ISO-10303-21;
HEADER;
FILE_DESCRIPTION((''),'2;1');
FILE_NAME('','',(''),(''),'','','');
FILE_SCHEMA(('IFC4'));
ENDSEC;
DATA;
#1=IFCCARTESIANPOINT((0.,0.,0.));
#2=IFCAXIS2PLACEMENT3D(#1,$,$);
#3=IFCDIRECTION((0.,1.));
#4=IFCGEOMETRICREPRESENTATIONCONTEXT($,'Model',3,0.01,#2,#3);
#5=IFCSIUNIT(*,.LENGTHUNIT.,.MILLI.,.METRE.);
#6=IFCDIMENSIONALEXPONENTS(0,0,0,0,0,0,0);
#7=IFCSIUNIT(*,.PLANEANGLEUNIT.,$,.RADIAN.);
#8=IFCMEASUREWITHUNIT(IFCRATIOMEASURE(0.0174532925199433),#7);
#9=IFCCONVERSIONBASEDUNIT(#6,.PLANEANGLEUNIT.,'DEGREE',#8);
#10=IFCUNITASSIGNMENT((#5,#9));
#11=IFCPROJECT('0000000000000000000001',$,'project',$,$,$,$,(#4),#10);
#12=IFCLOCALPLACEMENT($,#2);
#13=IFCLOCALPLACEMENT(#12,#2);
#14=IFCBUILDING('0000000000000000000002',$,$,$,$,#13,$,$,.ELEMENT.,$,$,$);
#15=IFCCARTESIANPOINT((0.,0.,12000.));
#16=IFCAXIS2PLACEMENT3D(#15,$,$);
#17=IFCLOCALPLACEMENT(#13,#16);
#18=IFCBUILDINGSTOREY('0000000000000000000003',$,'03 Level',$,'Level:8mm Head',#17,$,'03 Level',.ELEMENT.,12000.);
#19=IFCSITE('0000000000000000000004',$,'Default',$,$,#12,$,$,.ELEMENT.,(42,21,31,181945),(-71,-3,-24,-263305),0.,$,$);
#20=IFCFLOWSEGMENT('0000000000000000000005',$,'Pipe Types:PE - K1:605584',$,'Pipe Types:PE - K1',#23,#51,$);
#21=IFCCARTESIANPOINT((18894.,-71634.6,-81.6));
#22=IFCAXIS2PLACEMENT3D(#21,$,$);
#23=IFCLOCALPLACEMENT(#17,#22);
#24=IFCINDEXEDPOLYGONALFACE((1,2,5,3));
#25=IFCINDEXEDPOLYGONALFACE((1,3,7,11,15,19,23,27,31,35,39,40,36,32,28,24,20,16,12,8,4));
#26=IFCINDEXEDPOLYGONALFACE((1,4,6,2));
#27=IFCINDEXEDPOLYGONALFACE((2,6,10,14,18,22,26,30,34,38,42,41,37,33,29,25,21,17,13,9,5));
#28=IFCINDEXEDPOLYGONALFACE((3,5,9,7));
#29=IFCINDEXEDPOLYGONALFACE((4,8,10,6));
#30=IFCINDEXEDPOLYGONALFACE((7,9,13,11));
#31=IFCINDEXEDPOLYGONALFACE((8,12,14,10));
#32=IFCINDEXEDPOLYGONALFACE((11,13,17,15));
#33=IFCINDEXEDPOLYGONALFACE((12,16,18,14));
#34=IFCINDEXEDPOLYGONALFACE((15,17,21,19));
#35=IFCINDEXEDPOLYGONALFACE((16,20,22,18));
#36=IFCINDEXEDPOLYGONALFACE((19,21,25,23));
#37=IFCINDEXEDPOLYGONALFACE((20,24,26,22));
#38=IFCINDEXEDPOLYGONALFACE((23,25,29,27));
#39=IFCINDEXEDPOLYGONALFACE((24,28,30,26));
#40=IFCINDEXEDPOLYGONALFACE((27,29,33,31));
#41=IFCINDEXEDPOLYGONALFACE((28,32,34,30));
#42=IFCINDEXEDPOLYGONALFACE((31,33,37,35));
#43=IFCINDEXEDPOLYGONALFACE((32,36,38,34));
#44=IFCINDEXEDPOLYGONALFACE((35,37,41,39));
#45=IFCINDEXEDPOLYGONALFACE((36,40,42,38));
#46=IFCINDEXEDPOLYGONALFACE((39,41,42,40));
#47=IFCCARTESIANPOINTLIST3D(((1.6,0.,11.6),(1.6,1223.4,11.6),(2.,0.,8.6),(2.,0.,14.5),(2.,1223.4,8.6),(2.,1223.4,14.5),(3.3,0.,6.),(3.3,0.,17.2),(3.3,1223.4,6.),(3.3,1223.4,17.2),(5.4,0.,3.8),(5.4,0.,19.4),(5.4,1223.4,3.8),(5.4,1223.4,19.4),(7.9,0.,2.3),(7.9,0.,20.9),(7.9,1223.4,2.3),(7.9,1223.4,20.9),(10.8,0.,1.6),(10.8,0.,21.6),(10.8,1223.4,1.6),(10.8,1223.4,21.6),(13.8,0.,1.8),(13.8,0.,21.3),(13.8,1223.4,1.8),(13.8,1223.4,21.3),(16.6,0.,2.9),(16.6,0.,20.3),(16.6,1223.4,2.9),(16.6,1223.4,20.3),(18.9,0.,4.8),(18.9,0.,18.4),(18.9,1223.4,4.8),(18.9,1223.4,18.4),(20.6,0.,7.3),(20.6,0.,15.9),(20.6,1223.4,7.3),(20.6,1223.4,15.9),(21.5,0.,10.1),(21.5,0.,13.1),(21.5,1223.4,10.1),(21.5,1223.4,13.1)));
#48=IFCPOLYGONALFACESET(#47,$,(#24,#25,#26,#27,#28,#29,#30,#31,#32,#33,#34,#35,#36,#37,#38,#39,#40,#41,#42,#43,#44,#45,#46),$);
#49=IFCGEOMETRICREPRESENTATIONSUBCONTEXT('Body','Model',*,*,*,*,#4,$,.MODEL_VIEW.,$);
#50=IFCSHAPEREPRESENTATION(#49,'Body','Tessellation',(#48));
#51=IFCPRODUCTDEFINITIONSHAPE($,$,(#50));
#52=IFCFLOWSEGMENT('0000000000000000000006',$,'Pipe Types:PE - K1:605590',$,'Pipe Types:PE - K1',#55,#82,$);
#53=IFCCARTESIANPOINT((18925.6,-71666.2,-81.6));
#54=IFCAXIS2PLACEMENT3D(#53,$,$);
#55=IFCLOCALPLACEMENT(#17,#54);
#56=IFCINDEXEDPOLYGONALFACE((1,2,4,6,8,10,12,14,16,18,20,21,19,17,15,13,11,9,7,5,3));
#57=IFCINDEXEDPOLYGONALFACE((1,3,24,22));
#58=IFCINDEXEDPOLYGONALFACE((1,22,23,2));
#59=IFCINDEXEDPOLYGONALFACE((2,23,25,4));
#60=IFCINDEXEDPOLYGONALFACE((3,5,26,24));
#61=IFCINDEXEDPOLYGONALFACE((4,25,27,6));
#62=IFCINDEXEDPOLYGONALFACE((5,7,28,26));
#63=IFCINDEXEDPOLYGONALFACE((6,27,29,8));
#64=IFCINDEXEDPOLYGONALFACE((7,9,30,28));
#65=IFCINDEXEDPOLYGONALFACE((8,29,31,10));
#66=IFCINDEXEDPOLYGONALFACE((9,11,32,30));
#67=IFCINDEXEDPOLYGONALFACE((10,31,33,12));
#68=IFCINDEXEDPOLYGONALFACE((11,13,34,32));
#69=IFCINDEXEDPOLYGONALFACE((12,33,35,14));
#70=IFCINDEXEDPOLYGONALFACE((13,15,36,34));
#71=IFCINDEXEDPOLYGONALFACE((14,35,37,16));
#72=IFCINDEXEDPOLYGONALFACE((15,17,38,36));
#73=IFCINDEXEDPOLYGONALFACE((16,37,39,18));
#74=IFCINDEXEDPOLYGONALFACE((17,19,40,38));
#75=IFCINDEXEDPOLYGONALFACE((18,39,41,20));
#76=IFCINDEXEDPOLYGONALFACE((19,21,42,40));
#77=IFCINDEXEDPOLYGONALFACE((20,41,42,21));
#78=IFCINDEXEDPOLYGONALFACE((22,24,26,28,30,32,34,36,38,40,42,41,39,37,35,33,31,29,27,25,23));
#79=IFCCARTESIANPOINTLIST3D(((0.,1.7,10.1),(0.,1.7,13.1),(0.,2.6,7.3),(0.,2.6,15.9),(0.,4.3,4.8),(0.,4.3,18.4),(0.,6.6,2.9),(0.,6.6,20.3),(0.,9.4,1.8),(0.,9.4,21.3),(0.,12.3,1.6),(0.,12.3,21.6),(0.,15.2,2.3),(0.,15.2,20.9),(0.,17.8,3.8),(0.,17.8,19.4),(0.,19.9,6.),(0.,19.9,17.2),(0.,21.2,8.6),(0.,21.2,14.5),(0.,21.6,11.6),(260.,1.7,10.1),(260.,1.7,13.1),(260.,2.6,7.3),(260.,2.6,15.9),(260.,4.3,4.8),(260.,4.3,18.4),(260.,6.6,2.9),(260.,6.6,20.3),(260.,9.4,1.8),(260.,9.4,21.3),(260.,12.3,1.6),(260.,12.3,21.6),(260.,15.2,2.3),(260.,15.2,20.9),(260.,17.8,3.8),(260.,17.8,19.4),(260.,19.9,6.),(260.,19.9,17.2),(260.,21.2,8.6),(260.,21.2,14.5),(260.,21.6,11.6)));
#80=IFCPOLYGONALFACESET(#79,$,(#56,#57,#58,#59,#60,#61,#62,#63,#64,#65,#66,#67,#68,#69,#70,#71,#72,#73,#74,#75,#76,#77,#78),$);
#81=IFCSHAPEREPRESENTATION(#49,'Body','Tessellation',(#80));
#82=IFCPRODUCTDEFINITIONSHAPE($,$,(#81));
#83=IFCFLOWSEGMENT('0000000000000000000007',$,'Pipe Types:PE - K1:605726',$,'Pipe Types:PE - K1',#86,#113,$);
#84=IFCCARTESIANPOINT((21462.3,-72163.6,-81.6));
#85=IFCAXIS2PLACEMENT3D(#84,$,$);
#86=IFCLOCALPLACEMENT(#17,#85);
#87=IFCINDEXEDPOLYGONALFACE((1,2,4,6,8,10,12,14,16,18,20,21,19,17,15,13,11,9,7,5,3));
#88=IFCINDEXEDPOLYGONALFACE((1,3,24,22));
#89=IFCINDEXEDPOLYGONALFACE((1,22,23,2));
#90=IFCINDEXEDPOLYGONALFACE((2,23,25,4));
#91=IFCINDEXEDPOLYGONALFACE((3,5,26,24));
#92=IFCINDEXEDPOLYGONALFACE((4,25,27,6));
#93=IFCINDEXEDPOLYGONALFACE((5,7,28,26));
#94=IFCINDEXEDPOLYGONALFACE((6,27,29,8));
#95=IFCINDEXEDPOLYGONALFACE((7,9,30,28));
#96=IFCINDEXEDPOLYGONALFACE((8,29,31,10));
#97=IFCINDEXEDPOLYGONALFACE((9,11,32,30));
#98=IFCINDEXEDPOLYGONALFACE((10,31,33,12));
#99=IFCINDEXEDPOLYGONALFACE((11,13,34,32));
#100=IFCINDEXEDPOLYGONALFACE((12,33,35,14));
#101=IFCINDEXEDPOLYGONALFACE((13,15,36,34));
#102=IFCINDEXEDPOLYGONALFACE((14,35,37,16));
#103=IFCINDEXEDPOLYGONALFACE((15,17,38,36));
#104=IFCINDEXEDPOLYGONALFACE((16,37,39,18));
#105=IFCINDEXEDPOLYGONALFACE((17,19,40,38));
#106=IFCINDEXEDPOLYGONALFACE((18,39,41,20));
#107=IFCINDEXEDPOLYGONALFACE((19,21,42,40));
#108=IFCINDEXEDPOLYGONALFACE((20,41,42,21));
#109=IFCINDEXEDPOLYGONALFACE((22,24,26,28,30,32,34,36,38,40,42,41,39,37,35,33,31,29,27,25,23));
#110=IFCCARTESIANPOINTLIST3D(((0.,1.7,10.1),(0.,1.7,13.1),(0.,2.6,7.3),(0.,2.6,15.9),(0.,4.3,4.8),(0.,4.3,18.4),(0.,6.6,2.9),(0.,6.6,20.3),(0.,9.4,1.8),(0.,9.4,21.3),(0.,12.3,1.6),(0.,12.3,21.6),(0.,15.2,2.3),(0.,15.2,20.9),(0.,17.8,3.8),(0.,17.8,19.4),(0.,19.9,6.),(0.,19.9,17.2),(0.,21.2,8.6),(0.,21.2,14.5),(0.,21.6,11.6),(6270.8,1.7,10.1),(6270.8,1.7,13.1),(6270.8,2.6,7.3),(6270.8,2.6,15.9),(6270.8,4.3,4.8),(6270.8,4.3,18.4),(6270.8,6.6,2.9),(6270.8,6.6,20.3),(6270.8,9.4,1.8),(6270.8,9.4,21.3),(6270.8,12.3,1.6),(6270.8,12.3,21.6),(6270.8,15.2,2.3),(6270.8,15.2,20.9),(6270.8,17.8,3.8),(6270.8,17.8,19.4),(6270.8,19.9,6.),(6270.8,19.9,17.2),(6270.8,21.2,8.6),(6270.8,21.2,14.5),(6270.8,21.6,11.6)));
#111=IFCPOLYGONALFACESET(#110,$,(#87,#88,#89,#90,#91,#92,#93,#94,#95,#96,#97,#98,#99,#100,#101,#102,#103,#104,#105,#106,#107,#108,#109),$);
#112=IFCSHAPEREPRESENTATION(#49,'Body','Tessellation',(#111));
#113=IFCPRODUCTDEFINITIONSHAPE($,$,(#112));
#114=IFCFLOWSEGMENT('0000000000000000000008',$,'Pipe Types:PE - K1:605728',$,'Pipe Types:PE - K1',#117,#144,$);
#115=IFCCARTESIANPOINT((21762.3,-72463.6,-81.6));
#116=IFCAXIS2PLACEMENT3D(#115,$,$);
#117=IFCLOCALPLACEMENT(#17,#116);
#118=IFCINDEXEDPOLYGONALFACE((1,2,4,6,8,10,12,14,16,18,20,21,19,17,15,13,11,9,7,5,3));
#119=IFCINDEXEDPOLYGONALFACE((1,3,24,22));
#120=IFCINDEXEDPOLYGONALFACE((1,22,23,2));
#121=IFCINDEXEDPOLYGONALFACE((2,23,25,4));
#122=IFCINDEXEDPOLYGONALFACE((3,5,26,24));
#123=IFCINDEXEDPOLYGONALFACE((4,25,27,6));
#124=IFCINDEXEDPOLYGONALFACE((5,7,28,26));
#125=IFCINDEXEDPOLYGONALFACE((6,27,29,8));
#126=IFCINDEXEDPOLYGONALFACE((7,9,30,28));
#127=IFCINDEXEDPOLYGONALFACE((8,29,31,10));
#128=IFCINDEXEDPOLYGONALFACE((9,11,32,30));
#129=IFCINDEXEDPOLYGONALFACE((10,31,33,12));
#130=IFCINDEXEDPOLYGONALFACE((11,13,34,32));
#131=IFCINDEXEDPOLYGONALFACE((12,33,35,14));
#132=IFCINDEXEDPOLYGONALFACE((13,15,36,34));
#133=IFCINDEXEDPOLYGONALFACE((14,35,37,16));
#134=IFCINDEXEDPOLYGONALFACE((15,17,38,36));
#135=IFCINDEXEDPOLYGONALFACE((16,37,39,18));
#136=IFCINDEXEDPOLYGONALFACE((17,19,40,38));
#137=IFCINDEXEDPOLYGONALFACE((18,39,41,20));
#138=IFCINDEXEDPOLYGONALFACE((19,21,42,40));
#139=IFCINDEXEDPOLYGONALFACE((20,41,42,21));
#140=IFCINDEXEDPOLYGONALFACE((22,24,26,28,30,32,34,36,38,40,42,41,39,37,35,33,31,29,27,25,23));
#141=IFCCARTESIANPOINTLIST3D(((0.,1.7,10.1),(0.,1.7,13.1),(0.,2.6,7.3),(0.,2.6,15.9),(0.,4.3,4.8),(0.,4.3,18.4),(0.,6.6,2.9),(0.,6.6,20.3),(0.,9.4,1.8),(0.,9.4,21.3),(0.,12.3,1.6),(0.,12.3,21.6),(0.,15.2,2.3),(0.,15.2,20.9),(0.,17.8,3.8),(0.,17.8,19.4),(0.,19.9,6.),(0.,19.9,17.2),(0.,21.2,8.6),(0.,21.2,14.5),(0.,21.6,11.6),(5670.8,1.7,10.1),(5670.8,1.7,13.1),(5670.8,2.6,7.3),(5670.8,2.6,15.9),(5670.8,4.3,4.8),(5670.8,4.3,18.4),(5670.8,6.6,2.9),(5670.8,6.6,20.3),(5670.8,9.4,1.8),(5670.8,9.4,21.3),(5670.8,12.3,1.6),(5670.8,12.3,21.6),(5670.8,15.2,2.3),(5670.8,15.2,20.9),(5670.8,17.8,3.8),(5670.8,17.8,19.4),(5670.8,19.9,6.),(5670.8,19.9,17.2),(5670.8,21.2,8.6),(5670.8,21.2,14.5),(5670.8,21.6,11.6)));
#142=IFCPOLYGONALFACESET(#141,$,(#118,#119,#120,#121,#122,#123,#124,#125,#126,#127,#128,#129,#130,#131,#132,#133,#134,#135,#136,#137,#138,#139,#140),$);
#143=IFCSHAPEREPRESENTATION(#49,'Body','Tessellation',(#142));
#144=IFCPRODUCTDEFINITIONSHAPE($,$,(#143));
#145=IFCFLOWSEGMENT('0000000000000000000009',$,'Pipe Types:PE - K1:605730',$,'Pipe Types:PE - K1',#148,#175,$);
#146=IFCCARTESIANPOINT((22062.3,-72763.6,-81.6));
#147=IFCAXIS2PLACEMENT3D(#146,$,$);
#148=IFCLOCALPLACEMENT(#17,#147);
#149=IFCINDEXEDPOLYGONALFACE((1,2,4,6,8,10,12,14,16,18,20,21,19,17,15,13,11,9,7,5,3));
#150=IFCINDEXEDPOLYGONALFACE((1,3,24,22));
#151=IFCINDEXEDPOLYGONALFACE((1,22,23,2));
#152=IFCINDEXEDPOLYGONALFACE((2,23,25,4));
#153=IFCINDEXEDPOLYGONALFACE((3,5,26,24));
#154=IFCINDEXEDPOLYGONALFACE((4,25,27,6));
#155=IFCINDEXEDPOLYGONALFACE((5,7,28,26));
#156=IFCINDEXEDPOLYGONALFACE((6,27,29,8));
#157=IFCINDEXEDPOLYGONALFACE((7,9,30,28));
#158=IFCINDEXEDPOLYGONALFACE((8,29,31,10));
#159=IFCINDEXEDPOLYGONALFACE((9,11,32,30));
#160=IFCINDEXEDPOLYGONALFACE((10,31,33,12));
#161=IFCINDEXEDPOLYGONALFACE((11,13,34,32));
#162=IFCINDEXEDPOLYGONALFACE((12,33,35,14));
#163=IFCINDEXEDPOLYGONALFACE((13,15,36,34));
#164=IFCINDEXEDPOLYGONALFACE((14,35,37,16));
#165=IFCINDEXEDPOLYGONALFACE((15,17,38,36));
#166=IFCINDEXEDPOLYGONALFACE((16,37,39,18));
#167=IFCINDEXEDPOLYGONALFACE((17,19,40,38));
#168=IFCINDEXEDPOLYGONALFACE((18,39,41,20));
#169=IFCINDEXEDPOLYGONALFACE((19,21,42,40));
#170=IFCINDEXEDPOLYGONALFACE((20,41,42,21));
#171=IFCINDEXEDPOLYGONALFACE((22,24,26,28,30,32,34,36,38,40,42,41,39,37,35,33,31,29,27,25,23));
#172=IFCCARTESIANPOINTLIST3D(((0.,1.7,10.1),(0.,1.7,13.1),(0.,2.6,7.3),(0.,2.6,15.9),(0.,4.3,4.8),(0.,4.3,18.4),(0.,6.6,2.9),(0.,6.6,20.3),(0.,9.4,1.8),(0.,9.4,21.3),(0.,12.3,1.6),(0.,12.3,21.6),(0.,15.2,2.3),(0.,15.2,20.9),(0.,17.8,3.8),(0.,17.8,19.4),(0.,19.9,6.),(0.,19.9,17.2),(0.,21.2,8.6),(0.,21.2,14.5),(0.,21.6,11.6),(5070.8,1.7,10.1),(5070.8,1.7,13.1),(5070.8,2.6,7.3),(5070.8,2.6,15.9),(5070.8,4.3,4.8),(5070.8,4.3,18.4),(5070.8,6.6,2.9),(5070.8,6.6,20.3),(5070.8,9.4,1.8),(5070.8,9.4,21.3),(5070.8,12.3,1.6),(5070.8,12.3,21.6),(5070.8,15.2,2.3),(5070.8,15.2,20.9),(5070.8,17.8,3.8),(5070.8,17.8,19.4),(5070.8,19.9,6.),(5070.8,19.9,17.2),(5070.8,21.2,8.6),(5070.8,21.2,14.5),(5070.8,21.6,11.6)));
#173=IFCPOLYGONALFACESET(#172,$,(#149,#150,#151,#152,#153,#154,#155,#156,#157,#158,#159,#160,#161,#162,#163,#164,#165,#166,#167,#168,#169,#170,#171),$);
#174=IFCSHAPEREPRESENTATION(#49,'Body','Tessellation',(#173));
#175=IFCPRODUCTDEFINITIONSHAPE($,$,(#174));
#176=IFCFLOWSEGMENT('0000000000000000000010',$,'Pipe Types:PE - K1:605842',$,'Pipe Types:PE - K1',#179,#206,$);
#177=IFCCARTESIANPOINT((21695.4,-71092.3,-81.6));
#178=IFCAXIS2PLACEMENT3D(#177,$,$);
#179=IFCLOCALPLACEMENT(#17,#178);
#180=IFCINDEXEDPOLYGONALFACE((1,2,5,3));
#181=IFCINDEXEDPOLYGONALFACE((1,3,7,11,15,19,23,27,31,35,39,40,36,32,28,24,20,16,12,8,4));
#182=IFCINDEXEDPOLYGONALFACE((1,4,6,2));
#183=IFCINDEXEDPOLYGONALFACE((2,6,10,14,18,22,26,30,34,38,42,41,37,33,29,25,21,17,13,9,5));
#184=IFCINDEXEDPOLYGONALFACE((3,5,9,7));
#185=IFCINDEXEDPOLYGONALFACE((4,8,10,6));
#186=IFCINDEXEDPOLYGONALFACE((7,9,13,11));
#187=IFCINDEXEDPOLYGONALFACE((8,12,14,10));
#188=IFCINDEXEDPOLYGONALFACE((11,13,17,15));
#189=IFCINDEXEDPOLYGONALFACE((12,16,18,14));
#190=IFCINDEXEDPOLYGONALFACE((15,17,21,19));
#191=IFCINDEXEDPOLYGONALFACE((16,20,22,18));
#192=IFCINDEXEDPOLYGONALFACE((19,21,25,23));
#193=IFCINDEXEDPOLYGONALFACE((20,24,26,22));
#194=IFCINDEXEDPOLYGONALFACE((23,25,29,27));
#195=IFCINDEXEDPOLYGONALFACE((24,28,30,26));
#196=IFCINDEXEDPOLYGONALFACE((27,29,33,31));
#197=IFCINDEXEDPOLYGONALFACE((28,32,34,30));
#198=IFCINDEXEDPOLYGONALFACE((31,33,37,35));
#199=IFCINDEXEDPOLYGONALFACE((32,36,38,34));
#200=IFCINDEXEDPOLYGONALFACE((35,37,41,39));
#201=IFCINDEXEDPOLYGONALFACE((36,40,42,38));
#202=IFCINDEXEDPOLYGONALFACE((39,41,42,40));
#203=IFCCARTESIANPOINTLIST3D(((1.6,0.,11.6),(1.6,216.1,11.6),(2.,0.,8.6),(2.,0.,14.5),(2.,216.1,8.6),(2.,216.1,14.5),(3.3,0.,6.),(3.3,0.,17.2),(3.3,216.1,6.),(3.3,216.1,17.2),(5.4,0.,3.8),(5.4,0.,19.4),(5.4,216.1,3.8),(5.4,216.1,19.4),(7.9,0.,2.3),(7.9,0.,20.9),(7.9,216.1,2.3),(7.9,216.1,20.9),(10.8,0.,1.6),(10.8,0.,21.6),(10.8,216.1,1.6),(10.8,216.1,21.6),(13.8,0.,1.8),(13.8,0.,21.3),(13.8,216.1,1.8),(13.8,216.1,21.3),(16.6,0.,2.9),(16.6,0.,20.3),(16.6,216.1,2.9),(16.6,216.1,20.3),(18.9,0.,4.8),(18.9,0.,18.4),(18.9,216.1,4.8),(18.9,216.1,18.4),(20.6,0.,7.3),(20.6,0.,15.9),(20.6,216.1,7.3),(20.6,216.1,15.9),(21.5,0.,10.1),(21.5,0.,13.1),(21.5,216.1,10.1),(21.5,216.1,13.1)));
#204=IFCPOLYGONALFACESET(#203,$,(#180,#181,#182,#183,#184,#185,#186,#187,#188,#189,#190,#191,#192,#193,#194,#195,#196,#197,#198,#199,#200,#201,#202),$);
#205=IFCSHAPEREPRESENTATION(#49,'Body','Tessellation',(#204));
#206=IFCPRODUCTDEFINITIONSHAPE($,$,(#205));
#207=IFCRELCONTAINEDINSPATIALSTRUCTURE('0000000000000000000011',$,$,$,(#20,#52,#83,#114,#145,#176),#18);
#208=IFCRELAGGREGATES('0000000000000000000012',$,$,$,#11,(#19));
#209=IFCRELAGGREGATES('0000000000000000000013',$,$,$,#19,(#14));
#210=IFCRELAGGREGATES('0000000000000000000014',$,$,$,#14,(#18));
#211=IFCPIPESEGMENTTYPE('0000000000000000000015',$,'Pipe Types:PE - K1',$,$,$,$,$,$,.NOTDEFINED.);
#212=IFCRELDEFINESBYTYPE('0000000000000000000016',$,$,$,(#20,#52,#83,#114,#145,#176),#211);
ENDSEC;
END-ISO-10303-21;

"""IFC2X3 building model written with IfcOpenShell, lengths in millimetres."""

from ifc_helpers import new_model, entity, si_unit, converted_unit, direction, frame, frame_2d, origin, place, context, subcontext, project, spatial, circle, extrude, type_object, element, save


model = new_model("IFC2X3")

# Units and contexts
model_context = context("Model", 3, precision=0.01, world=origin(), true_north=direction((0.0, 1.0)))
body_context = subcontext(model_context, "Body", "Model", "MODEL_VIEW")
ifc_project = project(units=[si_unit("LENGTHUNIT", "METRE", prefix="MILLI"), converted_unit("PLANEANGLEUNIT", "DEGREE", entity("IfcRatioMeasure", 0.0174532925199433), si_unit("PLANEANGLEUNIT", "RADIAN"), dimensions=[0, 0, 0, 0, 0, 0, 0])], contexts=[model_context])

# Site, building, storey
site_placement = place(None, origin())
site = spatial("IfcSite", under=ifc_project, at=site_placement, Name="Default", CompositionType="ELEMENT", RefLatitude=(42, 21, 31, 181945), RefLongitude=(-71, -3, -24, -263305), RefElevation=0.0)
building_placement = place(site_placement, origin())
building = spatial("IfcBuilding", under=site, at=building_placement, CompositionType="ELEMENT")
storey_placement = place(building_placement, frame((0.0, 0.0, 12000.0)))
storey = spatial("IfcBuildingStorey", under=building, at=storey_placement, Name="03 Level", ObjectType="Level:8mm Head", LongName="03 Level", CompositionType="ELEMENT", Elevation=12000.0)

# Flow segments
pipe_segment_type = type_object("IfcPipeSegmentType", Name="Pipe Types:PE - K1", PredefinedType="NOTDEFINED")
flow_segment_1_placement = place(storey_placement, frame((18894.0, -71634.6, -81.6)))
element("IfcFlowSegment", 1, at=flow_segment_1_placement, inside=storey, type_object=pipe_segment_type, Name="Pipe Types:PE - K1:605584", ObjectType="Pipe Types:PE - K1", context=body_context, shape_type="SweptSolid", body=[
    extrude(circle(Radius=10.0, at=frame_2d((0.0, 0.0), x_axis=(1.0, 0.0))), frame((11.6, 0.0, 11.6), z_axis=(0.0, 1.0, 0.0), x_axis=(-1.0, 0.0, 0.0)), (0.0, 0.0, 1.0), 1223.4),
])
flow_segment_2_placement = place(storey_placement, frame((18925.6, -71666.2, -81.6)))
element("IfcFlowSegment", 2, at=flow_segment_2_placement, inside=storey, type_object=pipe_segment_type, Name="Pipe Types:PE - K1:605590", ObjectType="Pipe Types:PE - K1", context=body_context, shape_type="SweptSolid", body=[
    extrude(circle(Radius=10.0, at=frame_2d((0.0, 0.0), x_axis=(1.0, 0.0))), frame((0.0, 11.6, 11.6), z_axis=(1.0, 0.0, 0.0), x_axis=(0.0, 1.0, 0.0)), (0.0, 0.0, 1.0), 260.0),
])
flow_segment_3_placement = place(storey_placement, frame((21462.3, -72163.6, -81.6)))
element("IfcFlowSegment", 3, at=flow_segment_3_placement, inside=storey, type_object=pipe_segment_type, Name="Pipe Types:PE - K1:605726", ObjectType="Pipe Types:PE - K1", context=body_context, shape_type="SweptSolid", body=[
    extrude(circle(Radius=10.0, at=frame_2d((0.0, 0.0), x_axis=(1.0, 0.0))), frame((0.0, 11.6, 11.6), z_axis=(1.0, 0.0, 0.0), x_axis=(0.0, 1.0, 0.0)), (0.0, 0.0, 1.0), 6270.8),
])
flow_segment_4_placement = place(storey_placement, frame((21762.3, -72463.6, -81.6)))
element("IfcFlowSegment", 4, at=flow_segment_4_placement, inside=storey, type_object=pipe_segment_type, Name="Pipe Types:PE - K1:605728", ObjectType="Pipe Types:PE - K1", context=body_context, shape_type="SweptSolid", body=[
    extrude(circle(Radius=10.0, at=frame_2d((0.0, 0.0), x_axis=(1.0, 0.0))), frame((0.0, 11.6, 11.6), z_axis=(1.0, 0.0, 0.0), x_axis=(0.0, 1.0, 0.0)), (0.0, 0.0, 1.0), 5670.8),
])
flow_segment_5_placement = place(storey_placement, frame((22062.3, -72763.6, -81.6)))
element("IfcFlowSegment", 5, at=flow_segment_5_placement, inside=storey, type_object=pipe_segment_type, Name="Pipe Types:PE - K1:605730", ObjectType="Pipe Types:PE - K1", context=body_context, shape_type="SweptSolid", body=[
    extrude(circle(Radius=10.0, at=frame_2d((0.0, 0.0), x_axis=(1.0, 0.0))), frame((0.0, 11.6, 11.6), z_axis=(1.0, 0.0, 0.0), x_axis=(0.0, 1.0, 0.0)), (0.0, 0.0, 1.0), 5070.8),
])
flow_segment_6_placement = place(storey_placement, frame((21695.4, -71092.3, -81.6)))
element("IfcFlowSegment", 6, at=flow_segment_6_placement, inside=storey, type_object=pipe_segment_type, Name="Pipe Types:PE - K1:605842", ObjectType="Pipe Types:PE - K1", context=body_context, shape_type="SweptSolid", body=[
    extrude(circle(Radius=10.0, at=frame_2d((0.0, 0.0), x_axis=(1.0, 0.0))), frame((11.6, 0.0, 11.6), z_axis=(0.0, 1.0, 0.0), x_axis=(-1.0, 0.0, 0.0)), (0.0, 0.0, 1.0), 216.1),
])

save(model, "model.ifc")
